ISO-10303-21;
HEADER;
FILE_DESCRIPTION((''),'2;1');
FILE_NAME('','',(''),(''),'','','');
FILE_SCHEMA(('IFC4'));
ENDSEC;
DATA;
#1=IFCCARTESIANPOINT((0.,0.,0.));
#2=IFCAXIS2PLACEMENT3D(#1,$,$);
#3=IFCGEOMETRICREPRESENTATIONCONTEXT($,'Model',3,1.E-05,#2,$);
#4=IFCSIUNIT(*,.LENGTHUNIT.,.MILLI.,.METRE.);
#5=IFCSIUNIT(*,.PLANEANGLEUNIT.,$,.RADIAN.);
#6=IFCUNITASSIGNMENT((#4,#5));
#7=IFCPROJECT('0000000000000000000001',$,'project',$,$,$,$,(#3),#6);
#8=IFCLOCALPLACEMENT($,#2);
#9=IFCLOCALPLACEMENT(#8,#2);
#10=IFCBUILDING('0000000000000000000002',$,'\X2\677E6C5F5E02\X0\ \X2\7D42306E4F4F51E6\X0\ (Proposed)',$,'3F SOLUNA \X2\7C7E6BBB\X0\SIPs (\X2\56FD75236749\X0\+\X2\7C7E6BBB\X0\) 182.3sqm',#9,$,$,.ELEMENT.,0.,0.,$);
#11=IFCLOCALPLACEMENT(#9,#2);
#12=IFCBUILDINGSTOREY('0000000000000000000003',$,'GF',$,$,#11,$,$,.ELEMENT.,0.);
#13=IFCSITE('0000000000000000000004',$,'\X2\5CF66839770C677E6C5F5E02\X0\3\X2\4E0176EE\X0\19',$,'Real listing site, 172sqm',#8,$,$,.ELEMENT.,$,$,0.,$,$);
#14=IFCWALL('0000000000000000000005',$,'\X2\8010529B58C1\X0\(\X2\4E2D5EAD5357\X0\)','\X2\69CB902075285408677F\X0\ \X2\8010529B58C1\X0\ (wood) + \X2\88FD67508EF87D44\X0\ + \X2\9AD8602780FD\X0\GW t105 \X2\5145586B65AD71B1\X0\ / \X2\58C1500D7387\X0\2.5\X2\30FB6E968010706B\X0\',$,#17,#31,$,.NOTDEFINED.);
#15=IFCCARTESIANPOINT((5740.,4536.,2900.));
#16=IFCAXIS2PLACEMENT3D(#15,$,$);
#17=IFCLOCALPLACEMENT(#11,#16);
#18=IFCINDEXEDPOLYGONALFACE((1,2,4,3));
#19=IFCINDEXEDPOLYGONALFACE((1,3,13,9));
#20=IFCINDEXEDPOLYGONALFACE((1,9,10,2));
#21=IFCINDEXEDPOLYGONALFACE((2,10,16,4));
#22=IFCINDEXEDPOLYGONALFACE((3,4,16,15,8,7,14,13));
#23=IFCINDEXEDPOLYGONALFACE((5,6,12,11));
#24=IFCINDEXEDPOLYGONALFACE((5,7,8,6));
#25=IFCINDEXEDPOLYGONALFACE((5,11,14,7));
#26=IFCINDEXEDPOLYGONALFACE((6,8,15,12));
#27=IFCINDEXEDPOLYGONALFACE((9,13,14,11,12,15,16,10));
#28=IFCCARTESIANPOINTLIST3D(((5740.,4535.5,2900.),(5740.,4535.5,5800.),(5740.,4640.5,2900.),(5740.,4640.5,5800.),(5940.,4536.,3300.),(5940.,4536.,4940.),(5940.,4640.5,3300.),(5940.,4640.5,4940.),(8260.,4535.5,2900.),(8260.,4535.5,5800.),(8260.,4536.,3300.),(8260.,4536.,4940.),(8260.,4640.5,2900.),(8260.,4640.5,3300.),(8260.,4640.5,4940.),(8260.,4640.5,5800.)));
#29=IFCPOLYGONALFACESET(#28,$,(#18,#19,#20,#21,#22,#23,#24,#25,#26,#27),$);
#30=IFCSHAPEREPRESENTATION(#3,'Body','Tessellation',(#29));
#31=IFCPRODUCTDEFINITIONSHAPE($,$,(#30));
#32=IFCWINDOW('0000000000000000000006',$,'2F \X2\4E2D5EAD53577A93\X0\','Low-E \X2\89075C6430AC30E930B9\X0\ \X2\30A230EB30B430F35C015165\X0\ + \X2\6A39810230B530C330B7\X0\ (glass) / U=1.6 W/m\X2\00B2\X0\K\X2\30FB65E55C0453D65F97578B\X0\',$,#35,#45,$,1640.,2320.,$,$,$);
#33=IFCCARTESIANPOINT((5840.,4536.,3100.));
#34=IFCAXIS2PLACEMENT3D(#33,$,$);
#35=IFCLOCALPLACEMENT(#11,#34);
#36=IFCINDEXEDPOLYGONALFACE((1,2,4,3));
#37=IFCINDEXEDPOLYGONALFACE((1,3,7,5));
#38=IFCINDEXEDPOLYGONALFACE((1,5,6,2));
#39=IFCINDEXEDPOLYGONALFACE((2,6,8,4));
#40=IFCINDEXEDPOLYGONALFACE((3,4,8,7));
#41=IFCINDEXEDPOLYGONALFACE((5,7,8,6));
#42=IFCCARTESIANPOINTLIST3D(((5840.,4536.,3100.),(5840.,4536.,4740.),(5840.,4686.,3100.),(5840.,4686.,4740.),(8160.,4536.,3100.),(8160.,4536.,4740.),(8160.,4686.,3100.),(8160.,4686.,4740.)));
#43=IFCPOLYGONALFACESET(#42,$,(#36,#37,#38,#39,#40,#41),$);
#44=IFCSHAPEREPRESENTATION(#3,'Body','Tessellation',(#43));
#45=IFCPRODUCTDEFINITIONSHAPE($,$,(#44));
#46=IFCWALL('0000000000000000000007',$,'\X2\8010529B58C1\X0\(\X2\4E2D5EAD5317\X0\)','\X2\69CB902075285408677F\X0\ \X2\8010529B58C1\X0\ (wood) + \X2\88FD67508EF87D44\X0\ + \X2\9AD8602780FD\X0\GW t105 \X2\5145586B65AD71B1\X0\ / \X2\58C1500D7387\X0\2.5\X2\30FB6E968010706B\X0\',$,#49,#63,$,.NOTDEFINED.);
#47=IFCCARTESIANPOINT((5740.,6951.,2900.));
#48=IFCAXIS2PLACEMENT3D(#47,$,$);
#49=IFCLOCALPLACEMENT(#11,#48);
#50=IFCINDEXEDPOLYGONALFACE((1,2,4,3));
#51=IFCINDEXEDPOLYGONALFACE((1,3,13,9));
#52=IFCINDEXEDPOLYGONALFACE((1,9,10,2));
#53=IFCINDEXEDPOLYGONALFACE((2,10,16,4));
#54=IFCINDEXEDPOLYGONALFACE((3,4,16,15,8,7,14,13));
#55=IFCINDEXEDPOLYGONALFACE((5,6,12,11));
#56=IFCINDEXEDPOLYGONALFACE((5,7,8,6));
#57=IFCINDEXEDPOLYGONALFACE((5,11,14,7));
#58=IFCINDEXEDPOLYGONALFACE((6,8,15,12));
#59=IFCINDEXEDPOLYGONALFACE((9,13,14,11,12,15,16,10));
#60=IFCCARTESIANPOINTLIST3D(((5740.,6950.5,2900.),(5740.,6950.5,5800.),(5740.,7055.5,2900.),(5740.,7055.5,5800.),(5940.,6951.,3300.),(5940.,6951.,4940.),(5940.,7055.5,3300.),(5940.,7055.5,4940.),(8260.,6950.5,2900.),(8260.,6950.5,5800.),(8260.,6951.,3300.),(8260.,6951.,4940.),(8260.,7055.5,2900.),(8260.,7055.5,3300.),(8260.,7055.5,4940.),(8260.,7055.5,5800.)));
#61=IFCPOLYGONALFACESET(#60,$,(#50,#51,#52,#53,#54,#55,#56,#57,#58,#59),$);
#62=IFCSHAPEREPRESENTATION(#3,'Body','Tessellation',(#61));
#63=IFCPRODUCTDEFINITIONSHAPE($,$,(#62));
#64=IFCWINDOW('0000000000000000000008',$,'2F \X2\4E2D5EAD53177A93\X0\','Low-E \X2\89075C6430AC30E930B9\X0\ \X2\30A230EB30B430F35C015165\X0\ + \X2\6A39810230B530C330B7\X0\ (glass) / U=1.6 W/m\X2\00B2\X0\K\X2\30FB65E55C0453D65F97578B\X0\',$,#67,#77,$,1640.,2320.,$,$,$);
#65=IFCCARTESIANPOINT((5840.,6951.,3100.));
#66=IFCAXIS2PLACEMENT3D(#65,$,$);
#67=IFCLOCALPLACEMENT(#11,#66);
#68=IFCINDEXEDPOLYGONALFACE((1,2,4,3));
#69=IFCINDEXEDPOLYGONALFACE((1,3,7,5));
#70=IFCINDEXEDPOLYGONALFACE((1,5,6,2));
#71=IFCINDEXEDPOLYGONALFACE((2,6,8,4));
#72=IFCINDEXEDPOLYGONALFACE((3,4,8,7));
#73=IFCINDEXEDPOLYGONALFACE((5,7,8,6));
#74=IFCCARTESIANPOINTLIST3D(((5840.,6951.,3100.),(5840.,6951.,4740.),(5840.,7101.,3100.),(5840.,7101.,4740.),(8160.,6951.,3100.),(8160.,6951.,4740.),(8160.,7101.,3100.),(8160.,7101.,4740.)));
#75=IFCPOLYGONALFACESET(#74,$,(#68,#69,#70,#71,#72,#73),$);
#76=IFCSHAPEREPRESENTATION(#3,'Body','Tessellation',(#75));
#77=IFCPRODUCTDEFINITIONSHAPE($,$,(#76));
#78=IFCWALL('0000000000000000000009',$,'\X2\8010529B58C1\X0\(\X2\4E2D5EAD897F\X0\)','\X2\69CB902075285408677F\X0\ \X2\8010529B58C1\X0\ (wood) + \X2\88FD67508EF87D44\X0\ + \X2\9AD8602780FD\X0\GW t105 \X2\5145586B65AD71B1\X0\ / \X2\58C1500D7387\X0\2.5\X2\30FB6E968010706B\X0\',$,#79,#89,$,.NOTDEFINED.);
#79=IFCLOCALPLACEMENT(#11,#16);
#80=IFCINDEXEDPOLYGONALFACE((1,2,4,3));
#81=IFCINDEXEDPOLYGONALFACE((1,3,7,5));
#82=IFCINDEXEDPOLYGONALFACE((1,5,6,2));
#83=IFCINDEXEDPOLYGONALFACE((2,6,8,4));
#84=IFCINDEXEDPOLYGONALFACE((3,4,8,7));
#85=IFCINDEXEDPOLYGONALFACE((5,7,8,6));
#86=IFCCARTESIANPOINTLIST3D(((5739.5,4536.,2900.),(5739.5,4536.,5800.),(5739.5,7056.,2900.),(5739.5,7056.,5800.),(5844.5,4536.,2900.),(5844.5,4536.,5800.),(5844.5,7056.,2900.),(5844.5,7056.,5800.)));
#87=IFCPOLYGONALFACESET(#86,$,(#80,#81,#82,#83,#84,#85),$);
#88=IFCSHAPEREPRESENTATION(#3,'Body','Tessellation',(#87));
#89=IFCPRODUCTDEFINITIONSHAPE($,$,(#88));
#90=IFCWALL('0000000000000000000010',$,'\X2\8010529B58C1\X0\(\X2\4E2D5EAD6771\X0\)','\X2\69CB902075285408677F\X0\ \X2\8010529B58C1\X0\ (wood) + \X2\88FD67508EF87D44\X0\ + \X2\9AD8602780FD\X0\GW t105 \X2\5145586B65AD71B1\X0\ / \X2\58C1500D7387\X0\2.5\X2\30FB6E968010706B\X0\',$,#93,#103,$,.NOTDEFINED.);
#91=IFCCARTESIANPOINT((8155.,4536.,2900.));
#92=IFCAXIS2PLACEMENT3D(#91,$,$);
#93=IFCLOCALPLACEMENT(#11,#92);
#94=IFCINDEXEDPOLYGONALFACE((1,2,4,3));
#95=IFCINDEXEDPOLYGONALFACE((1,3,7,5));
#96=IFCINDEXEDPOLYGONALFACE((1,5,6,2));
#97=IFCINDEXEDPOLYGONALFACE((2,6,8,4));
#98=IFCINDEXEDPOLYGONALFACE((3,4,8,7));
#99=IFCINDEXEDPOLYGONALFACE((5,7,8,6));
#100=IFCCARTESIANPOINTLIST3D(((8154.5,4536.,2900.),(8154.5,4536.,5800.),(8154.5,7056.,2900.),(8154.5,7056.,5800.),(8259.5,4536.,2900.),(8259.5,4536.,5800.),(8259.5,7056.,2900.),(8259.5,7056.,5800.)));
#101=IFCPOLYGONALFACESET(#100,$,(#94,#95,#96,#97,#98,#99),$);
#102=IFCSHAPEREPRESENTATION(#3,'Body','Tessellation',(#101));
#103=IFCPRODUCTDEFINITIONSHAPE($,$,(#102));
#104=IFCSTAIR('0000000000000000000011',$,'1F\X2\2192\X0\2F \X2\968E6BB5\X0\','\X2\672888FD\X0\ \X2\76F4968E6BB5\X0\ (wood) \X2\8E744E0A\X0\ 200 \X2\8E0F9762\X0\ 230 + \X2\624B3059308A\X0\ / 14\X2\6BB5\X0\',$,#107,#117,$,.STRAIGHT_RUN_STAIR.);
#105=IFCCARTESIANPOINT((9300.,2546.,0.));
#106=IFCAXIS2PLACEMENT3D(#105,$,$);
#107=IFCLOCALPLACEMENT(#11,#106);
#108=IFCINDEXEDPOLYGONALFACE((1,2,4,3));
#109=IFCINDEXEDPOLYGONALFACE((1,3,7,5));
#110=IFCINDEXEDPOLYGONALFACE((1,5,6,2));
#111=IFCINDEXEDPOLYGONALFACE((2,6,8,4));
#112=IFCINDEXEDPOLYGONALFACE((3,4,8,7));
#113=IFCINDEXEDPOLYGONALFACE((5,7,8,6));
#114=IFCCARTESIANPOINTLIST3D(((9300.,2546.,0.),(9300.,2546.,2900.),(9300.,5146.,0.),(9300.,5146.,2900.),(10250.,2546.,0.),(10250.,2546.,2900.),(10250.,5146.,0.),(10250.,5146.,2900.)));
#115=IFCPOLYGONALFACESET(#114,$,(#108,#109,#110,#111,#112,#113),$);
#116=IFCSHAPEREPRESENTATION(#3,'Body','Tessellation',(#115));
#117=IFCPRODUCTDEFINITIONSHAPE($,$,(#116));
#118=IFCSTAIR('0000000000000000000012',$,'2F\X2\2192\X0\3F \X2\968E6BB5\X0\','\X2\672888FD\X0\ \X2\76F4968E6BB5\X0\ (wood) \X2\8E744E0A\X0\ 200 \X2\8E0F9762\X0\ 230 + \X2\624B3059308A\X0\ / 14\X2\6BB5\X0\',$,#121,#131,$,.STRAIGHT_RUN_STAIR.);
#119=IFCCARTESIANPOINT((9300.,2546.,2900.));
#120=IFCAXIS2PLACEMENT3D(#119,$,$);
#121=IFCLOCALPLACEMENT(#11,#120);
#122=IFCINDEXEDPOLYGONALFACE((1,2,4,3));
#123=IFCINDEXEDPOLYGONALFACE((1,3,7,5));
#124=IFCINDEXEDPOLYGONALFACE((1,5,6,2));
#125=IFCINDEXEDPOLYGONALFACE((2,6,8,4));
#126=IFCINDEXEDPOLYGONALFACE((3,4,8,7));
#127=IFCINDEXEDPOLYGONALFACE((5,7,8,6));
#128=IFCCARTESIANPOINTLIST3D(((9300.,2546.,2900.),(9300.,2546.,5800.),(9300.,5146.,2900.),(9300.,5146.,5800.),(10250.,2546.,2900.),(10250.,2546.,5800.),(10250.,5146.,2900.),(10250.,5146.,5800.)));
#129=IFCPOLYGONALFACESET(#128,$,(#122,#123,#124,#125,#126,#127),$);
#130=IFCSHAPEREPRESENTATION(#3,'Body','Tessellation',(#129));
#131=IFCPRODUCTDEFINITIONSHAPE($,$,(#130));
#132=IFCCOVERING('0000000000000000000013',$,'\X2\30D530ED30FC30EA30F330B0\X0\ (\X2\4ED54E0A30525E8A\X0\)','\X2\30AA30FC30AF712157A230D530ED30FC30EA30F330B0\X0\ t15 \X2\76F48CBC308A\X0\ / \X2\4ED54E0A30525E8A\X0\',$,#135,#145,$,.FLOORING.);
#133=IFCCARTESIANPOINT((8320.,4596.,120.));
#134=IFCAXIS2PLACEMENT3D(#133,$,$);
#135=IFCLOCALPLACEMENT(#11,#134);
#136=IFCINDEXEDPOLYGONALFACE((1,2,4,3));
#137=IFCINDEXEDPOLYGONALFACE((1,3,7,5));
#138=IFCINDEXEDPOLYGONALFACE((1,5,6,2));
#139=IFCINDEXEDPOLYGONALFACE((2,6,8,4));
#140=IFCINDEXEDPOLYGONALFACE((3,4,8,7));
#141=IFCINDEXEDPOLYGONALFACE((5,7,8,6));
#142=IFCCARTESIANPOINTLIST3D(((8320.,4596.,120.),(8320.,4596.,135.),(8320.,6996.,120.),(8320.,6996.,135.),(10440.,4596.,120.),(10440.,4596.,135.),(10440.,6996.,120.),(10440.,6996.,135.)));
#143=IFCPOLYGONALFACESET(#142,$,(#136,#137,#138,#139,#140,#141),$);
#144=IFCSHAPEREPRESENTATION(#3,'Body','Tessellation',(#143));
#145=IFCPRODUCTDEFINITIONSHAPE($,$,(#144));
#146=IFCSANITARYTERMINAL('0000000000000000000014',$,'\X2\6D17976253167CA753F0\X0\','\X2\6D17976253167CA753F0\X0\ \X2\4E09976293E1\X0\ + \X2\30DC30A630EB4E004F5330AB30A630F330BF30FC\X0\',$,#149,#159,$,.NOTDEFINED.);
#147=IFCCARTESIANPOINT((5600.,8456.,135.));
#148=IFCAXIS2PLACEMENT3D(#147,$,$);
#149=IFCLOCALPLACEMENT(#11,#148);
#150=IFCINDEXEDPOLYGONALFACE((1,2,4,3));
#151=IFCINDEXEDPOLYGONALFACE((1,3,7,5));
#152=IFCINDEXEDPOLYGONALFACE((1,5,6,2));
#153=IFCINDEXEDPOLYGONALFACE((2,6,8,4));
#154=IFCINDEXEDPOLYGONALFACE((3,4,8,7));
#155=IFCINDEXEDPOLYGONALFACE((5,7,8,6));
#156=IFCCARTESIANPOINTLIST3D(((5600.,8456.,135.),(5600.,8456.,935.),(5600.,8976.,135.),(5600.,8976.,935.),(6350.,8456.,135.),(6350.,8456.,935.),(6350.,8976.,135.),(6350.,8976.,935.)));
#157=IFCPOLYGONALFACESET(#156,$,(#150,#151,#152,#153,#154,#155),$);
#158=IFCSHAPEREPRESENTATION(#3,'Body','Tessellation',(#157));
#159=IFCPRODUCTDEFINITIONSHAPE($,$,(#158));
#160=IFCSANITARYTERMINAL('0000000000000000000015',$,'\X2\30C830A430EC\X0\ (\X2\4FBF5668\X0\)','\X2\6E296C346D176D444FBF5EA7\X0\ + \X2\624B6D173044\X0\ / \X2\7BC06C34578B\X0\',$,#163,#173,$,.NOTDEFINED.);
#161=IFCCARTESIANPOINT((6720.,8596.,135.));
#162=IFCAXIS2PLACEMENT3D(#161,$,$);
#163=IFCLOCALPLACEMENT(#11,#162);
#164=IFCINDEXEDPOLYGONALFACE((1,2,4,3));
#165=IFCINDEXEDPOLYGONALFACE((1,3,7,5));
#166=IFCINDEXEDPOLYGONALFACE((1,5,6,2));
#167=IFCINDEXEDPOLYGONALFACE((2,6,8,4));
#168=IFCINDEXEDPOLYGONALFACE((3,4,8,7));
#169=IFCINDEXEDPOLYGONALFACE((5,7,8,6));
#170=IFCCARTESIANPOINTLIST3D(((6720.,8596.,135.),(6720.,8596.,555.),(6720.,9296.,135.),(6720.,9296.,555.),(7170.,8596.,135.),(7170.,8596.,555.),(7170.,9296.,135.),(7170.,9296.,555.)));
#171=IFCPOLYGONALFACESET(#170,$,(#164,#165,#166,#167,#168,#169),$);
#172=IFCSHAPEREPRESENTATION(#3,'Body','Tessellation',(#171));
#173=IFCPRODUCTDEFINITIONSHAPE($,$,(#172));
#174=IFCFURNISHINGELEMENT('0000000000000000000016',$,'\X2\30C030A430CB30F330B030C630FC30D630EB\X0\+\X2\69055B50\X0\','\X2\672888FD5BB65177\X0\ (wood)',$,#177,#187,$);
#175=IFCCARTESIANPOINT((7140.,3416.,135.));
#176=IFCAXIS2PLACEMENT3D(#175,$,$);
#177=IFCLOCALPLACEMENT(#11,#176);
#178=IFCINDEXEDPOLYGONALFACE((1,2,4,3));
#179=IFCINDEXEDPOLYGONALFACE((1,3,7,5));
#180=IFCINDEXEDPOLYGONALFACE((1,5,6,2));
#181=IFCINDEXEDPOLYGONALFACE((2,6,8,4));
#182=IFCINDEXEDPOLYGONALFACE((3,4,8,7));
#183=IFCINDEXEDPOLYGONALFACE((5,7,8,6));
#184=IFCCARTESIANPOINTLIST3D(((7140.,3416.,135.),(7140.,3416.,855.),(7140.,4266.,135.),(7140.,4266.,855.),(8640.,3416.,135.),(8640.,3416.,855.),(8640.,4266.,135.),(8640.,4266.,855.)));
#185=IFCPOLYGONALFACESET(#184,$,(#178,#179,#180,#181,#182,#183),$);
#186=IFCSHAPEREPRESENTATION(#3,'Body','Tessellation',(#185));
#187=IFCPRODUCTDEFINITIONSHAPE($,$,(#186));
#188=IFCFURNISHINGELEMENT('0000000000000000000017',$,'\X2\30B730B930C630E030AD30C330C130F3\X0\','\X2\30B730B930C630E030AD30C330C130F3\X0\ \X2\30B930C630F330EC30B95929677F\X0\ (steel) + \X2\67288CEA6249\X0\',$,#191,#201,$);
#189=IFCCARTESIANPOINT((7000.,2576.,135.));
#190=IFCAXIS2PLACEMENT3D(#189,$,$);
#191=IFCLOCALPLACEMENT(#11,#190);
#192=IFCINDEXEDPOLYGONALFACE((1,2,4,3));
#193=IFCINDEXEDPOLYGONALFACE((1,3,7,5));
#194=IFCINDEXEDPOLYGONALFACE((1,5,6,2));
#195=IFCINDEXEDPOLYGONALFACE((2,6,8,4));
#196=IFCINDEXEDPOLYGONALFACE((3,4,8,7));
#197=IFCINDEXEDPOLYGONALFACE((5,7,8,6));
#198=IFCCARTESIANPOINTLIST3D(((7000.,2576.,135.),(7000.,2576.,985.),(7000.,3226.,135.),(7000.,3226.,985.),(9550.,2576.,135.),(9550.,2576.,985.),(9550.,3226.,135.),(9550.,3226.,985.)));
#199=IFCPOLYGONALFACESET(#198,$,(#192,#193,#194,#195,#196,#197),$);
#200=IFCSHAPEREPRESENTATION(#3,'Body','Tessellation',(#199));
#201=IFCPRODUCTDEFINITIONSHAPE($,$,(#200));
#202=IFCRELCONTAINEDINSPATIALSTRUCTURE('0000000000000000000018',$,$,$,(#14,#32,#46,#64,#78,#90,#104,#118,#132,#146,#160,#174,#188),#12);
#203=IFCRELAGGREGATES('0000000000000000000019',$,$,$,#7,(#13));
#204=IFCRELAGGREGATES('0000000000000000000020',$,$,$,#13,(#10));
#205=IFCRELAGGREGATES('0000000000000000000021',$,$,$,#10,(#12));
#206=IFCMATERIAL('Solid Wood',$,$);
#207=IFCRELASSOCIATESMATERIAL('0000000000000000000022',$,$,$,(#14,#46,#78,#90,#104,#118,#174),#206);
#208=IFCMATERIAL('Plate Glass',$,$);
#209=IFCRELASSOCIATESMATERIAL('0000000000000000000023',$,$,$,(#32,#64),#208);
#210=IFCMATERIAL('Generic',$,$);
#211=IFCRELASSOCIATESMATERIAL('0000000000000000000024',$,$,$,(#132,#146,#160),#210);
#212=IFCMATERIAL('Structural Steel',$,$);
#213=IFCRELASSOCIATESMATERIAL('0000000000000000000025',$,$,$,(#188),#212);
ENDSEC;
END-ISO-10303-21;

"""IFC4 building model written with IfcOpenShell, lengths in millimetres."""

from ifc_helpers import new_model, si_unit, frame, frame_2d, origin, place, context, project, spatial, rectangle, extrude, material, element, fill, save


model = new_model("IFC4")

# Units and contexts
model_context = context("Model", 3, precision=1e-05, world=origin())
ifc_project = project(units=[si_unit("LENGTHUNIT", "METRE", prefix="MILLI"), si_unit("PLANEANGLEUNIT", "RADIAN")], contexts=[model_context])

# Site, building, storey
site_placement = place(None, origin())
site = spatial("IfcSite", under=ifc_project, at=site_placement, Name="島根県松江市3丁目19", ObjectType="Real listing site, 172sqm", CompositionType="ELEMENT", RefElevation=0.0)
building_placement = place(site_placement, origin())
building = spatial("IfcBuilding", under=site, at=building_placement, Name="松江市 終の住処 (Proposed)", ObjectType="3F SOLUNA 籾殻SIPs (国産杉+籾殻) 182.3sqm", CompositionType="ELEMENT", ElevationOfRefHeight=0.0, ElevationOfTerrain=0.0)
storey_placement = place(building_placement, origin())
storey = spatial("IfcBuildingStorey", under=building, at=storey_placement, Name="GF", CompositionType="ELEMENT", Elevation=0.0)

# Shared definitions
ifc_material_1 = material(Name="Solid Wood")

# Shared definitions
ifc_material_2 = material(Name="Plate Glass")

# Walls, openings, windows
wall_1_placement = place(storey_placement, frame((5740.0, 4536.0, 2900.0)))
wall_1 = element("IfcWall", 1, at=wall_1_placement, inside=storey, material=ifc_material_1, Name="耐力壁(中庭南)", Description="構造用合板 耐力壁 (wood) + 製材軸組 + 高性能GW t105 充填断熱 / 壁倍率2.5・準耐火", PredefinedType="NOTDEFINED", context=model_context, shape_type="SweptSolid", body=[
    extrude(rectangle(XDim=2520.0, YDim=105.0, at=frame_2d((1260.0, 52.0))), frame((5740.0, 4536.0, 2900.0)), (0.0, 0.0, 1.0), 2900.0),
])
opening_1_placement = place(storey_placement, frame((5840.0, 4536.0, 3100.0)))
opening_1 = element("IfcOpeningElement", 2, at=opening_1_placement, cuts=wall_1, PredefinedType="NOTDEFINED", context=model_context, shape_type="SweptSolid", body=[
    extrude(rectangle(XDim=2320.0, YDim=150.0, at=frame_2d((1160.0, 75.0))), frame((5840.0, 4536.0, 3100.0)), (0.0, 0.0, 1.0), 1640.0),
])
window_1_placement = place(storey_placement, frame((5840.0, 4536.0, 3100.0)))
window_1 = element("IfcWindow", 3, at=window_1_placement, inside=storey, material=ifc_material_2, Name="2F 中庭南窓", Description="Low-E 複層ガラス アルゴン封入 + 樹脂サッシ (glass) / U=1.6 W/m²K・日射取得型", OverallHeight=1640.0, OverallWidth=2320.0, context=model_context, shape_type="SweptSolid", body=[
    extrude(rectangle(XDim=2320.0, YDim=150.0, at=frame_2d((1160.0, 75.0))), frame((5840.0, 4536.0, 3100.0)), (0.0, 0.0, 1.0), 1640.0),
])
fill(opening_1, window_1)
wall_2_placement = place(storey_placement, frame((5740.0, 6951.0, 2900.0)))
wall_2 = element("IfcWall", 4, at=wall_2_placement, inside=storey, material=ifc_material_1, Name="耐力壁(中庭北)", Description="構造用合板 耐力壁 (wood) + 製材軸組 + 高性能GW t105 充填断熱 / 壁倍率2.5・準耐火", PredefinedType="NOTDEFINED", context=model_context, shape_type="SweptSolid", body=[
    extrude(rectangle(XDim=2520.0, YDim=105.0, at=frame_2d((1260.0, 52.0))), frame((5740.0, 6951.0, 2900.0)), (0.0, 0.0, 1.0), 2900.0),
])
opening_2_placement = place(storey_placement, frame((5840.0, 6951.0, 3100.0)))
opening_2 = element("IfcOpeningElement", 5, at=opening_2_placement, cuts=wall_2, PredefinedType="NOTDEFINED", context=model_context, shape_type="SweptSolid", body=[
    extrude(rectangle(XDim=2320.0, YDim=150.0, at=frame_2d((1160.0, 75.0))), frame((5840.0, 6951.0, 3100.0)), (0.0, 0.0, 1.0), 1640.0),
])
window_2_placement = place(storey_placement, frame((5840.0, 6951.0, 3100.0)))
window_2 = element("IfcWindow", 6, at=window_2_placement, inside=storey, material=ifc_material_2, Name="2F 中庭北窓", Description="Low-E 複層ガラス アルゴン封入 + 樹脂サッシ (glass) / U=1.6 W/m²K・日射取得型", OverallHeight=1640.0, OverallWidth=2320.0, context=model_context, shape_type="SweptSolid", body=[
    extrude(rectangle(XDim=2320.0, YDim=150.0, at=frame_2d((1160.0, 75.0))), frame((5840.0, 6951.0, 3100.0)), (0.0, 0.0, 1.0), 1640.0),
])
fill(opening_2, window_2)

# Walls
wall_3_placement = place(storey_placement, frame((5740.0, 4536.0, 2900.0)))
element("IfcWall", 7, at=wall_3_placement, inside=storey, material=ifc_material_1, Name="耐力壁(中庭西)", Description="構造用合板 耐力壁 (wood) + 製材軸組 + 高性能GW t105 充填断熱 / 壁倍率2.5・準耐火", PredefinedType="NOTDEFINED", context=model_context, shape_type="SweptSolid", body=[
    extrude(rectangle(XDim=105.0, YDim=2520.0, at=frame_2d((52.0, 1260.0))), frame((5740.0, 4536.0, 2900.0)), (0.0, 0.0, 1.0), 2900.0),
])
wall_4_placement = place(storey_placement, frame((8155.0, 4536.0, 2900.0)))
element("IfcWall", 8, at=wall_4_placement, inside=storey, material=ifc_material_1, Name="耐力壁(中庭東)", Description="構造用合板 耐力壁 (wood) + 製材軸組 + 高性能GW t105 充填断熱 / 壁倍率2.5・準耐火", PredefinedType="NOTDEFINED", context=model_context, shape_type="SweptSolid", body=[
    extrude(rectangle(XDim=105.0, YDim=2520.0, at=frame_2d((52.0, 1260.0))), frame((8155.0, 4536.0, 2900.0)), (0.0, 0.0, 1.0), 2900.0),
])

# Stairs
stair_1_placement = place(storey_placement, frame((9300.0, 2546.0, 0.0)))
element("IfcStair", 9, at=stair_1_placement, inside=storey, material=ifc_material_1, Name="1F→2F 階段", Description="木製 直階段 (wood) 蹴上 200 踏面 230 + 手すり / 14段", PredefinedType="STRAIGHT_RUN_STAIR", context=model_context, shape_type="SweptSolid", body=[
    extrude(rectangle(XDim=950.0, YDim=2600.0, at=frame_2d((475.0, 1300.0))), frame((9300.0, 2546.0, 0.0)), (0.0, 0.0, 1.0), 2900.0),
])
stair_2_placement = place(storey_placement, frame((9300.0, 2546.0, 2900.0)))
element("IfcStair", 10, at=stair_2_placement, inside=storey, material=ifc_material_1, Name="2F→3F 階段", Description="木製 直階段 (wood) 蹴上 200 踏面 230 + 手すり / 14段", PredefinedType="STRAIGHT_RUN_STAIR", context=model_context, shape_type="SweptSolid", body=[
    extrude(rectangle(XDim=950.0, YDim=2600.0, at=frame_2d((475.0, 1300.0))), frame((9300.0, 2546.0, 2900.0)), (0.0, 0.0, 1.0), 2900.0),
])

# Covering
ifc_material_3 = material(Name="Generic")
covering_placement = place(storey_placement, frame((8320.0, 4596.0, 120.0)))
element("IfcCovering", 11, at=covering_placement, inside=storey, material=ifc_material_3, Name="フローリング (仕上げ床)", Description="オーク無垢フローリング t15 直貼り / 仕上げ床", PredefinedType="FLOORING", context=model_context, shape_type="SweptSolid", body=[
    extrude(rectangle(XDim=2120.0, YDim=2400.0, at=frame_2d((1060.0, 1200.0))), frame((8320.0, 4596.0, 120.0)), (0.0, 0.0, 1.0), 15.0),
])

# Sanitary terminals
sanitary_terminal_1_placement = place(storey_placement, frame((5600.0, 8456.0, 135.0)))
element("IfcSanitaryTerminal", 12, at=sanitary_terminal_1_placement, inside=storey, material=ifc_material_3, Name="洗面化粧台", Description="洗面化粧台 三面鏡 + ボウル一体カウンター", PredefinedType="NOTDEFINED", context=model_context, shape_type="SweptSolid", body=[
    extrude(rectangle(XDim=750.0, YDim=520.0, at=frame_2d((375.0, 260.0))), frame((5600.0, 8456.0, 135.0)), (0.0, 0.0, 1.0), 800.0),
])
sanitary_terminal_2_placement = place(storey_placement, frame((6720.0, 8596.0, 135.0)))
element("IfcSanitaryTerminal", 13, at=sanitary_terminal_2_placement, inside=storey, material=ifc_material_3, Name="トイレ (便器)", Description="温水洗浄便座 + 手洗い / 節水型", PredefinedType="NOTDEFINED", context=model_context, shape_type="SweptSolid", body=[
    extrude(rectangle(XDim=450.0, YDim=700.0, at=frame_2d((225.0, 350.0))), frame((6720.0, 8596.0, 135.0)), (0.0, 0.0, 1.0), 420.0),
])

# Furnishing elements
furnishing_1_placement = place(storey_placement, frame((7140.0, 3416.0, 135.0)))
element("IfcFurnishingElement", 14, at=furnishing_1_placement, inside=storey, material=ifc_material_1, Name="ダイニングテーブル+椅子", Description="木製家具 (wood)", context=model_context, shape_type="SweptSolid", body=[
    extrude(rectangle(XDim=1500.0, YDim=850.0, at=frame_2d((750.0, 425.0))), frame((7140.0, 3416.0, 135.0)), (0.0, 0.0, 1.0), 720.0),
])
ifc_material_4 = material(Name="Structural Steel")
furnishing_2_placement = place(storey_placement, frame((7000.0, 2576.0, 135.0)))
element("IfcFurnishingElement", 15, at=furnishing_2_placement, inside=storey, material=ifc_material_4, Name="システムキッチン", Description="システムキッチン ステンレス天板 (steel) + 木質扉", context=model_context, shape_type="SweptSolid", body=[
    extrude(rectangle(XDim=2550.0, YDim=650.0, at=frame_2d((1275.0, 325.0))), frame((7000.0, 2576.0, 135.0)), (0.0, 0.0, 1.0), 850.0),
])

save(model, "model.ifc")
